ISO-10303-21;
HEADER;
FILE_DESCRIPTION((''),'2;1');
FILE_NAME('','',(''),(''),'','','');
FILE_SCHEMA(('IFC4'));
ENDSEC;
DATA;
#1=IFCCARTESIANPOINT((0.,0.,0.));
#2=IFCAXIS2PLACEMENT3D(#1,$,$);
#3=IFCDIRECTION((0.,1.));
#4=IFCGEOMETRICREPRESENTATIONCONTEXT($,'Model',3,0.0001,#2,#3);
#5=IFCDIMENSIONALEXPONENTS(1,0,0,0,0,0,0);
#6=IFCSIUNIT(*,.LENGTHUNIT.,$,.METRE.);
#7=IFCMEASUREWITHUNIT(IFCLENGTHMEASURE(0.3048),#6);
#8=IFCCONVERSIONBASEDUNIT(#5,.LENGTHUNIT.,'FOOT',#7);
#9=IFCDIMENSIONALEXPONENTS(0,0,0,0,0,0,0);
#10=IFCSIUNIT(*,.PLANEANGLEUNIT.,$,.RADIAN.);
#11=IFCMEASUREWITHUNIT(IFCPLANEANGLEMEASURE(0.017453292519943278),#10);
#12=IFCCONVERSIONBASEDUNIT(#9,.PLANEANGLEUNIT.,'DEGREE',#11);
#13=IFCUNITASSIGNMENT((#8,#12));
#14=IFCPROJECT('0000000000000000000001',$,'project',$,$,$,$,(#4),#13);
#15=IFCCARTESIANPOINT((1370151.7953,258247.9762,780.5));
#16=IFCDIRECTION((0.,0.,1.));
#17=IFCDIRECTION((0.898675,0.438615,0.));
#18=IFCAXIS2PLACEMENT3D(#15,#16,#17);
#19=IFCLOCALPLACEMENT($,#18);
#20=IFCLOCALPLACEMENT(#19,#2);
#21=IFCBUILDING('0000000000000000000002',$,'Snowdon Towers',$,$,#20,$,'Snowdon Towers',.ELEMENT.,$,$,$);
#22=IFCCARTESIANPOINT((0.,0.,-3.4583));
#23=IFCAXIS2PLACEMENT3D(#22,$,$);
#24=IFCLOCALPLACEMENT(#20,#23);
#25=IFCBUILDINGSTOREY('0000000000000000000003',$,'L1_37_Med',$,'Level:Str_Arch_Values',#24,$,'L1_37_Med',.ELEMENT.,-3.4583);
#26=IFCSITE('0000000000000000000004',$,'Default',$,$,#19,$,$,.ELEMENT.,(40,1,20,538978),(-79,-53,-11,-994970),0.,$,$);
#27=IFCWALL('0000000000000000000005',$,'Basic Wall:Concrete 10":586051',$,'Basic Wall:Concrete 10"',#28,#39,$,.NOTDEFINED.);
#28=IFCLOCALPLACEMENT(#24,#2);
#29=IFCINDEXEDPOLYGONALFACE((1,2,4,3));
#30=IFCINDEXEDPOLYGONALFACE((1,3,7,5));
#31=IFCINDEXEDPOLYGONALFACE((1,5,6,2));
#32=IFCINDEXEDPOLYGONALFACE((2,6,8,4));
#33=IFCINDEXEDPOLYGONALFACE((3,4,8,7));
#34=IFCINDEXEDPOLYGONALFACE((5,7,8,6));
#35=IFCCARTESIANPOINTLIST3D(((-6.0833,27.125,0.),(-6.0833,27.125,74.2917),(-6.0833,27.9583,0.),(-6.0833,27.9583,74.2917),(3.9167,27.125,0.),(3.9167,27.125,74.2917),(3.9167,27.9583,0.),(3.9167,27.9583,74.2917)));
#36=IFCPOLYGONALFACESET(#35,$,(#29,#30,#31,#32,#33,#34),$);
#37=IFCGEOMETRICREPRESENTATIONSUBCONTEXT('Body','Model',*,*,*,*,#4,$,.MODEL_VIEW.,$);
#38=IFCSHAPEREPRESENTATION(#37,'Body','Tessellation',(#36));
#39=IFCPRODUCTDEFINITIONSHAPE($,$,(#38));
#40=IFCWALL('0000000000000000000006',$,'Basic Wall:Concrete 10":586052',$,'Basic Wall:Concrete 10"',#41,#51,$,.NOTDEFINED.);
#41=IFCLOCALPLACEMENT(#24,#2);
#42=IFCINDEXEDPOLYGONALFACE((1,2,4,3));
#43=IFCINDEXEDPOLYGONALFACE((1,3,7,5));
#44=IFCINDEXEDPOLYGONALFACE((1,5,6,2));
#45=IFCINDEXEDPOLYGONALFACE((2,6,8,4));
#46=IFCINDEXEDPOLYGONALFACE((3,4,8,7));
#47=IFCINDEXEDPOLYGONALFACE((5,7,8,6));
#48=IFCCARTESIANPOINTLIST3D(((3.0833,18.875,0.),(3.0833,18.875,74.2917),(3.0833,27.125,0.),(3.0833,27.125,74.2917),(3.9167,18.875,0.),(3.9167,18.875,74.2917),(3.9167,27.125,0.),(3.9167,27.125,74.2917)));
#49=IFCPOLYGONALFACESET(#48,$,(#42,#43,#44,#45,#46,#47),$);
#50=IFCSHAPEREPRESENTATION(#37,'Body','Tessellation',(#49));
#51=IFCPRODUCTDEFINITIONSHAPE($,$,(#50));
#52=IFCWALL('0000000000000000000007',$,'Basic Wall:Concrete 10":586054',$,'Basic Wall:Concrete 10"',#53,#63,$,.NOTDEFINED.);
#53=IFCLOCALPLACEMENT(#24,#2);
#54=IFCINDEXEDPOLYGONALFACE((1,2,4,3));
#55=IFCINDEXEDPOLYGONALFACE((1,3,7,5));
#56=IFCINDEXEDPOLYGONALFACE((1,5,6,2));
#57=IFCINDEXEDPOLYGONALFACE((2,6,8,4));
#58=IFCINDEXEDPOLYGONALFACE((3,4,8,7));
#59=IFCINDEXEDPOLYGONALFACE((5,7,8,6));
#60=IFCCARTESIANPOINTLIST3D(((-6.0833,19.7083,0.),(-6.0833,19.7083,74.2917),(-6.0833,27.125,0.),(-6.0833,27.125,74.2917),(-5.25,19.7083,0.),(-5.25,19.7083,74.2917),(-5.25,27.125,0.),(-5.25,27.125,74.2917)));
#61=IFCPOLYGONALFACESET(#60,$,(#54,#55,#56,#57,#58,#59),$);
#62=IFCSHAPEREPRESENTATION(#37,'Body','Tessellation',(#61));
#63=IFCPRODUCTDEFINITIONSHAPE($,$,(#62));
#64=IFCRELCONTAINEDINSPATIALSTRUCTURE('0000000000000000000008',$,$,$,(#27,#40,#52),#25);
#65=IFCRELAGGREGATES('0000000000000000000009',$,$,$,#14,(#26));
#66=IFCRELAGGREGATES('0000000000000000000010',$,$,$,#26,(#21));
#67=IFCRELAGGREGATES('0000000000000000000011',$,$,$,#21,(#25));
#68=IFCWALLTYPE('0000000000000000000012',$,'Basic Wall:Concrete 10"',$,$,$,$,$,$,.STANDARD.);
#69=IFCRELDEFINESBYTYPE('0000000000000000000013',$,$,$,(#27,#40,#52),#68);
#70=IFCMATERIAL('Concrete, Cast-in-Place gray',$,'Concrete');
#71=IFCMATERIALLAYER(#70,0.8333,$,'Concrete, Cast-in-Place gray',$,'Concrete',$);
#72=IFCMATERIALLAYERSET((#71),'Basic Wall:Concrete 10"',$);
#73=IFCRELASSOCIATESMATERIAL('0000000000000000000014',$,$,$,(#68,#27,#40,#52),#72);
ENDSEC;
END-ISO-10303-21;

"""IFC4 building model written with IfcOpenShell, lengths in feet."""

from ifc_helpers import new_model, entity, si_unit, converted_unit, direction, frame, frame_2d, origin, place, context, subcontext, project, spatial, rectangle, extrude, material, layer, layer_set, layer_usage, type_object, element, save


model = new_model("IFC4")

# Units and contexts
model_context = context("Model", 3, precision=0.0001, world=origin(), true_north=direction((0.0, 1.0)))
body_context = subcontext(model_context, "Body", "Model", "MODEL_VIEW")
ifc_project = project(units=[converted_unit("LENGTHUNIT", "FOOT", entity("IfcLengthMeasure", 0.3048), si_unit("LENGTHUNIT", "METRE"), dimensions=[1, 0, 0, 0, 0, 0, 0]), converted_unit("PLANEANGLEUNIT", "DEGREE", entity("IfcPlaneAngleMeasure", 0.017453292519943278), si_unit("PLANEANGLEUNIT", "RADIAN"), dimensions=[0, 0, 0, 0, 0, 0, 0])], contexts=[model_context])

# Site, building, storey
site_placement = place(None, frame((1370151.7953, 258247.9762, 780.5), z_axis=(0.0, 0.0, 1.0), x_axis=(0.898675, 0.438615, 0.0)))
site = spatial("IfcSite", under=ifc_project, at=site_placement, Name="Default", CompositionType="ELEMENT", RefLatitude=(40, 1, 20, 538978), RefLongitude=(-79, -53, -11, -994970), RefElevation=0.0)
building_placement = place(site_placement, origin())
building = spatial("IfcBuilding", under=site, at=building_placement, Name="Snowdon Towers", LongName="Snowdon Towers", CompositionType="ELEMENT")
storey_placement = place(building_placement, frame((0.0, 0.0, -3.4583)))
storey = spatial("IfcBuildingStorey", under=building, at=storey_placement, Name="L1_37_Med", ObjectType="Level:Str_Arch_Values", LongName="L1_37_Med", CompositionType="ELEMENT", Elevation=-3.4583)

# Walls
ifc_material = material(Name="Concrete, Cast-in-Place gray", Category="Concrete")
ifc_layer_1 = layer(ifc_material, 0.8333, Name="Concrete, Cast-in-Place gray", Category="Concrete")
ifc_layer_set_1 = layer_set([ifc_layer_1], Name="Basic Wall:Concrete 10\"")
ifc_layer_usage_1 = layer_usage(ifc_layer_set_1, "AXIS2", "POSITIVE", -0.4167)
wall_type_1 = type_object("IfcWallType", Name="Basic Wall:Concrete 10\"", PredefinedType="STANDARD", material=ifc_layer_set_1)
wall_1_placement = place(storey_placement, frame((-6.0833, 27.5417, 0.0)))
element("IfcWall", 1, at=wall_1_placement, inside=storey, type_object=wall_type_1, material=ifc_layer_usage_1, Name="Basic Wall:Concrete 10\":586051", ObjectType="Basic Wall:Concrete 10\"", PredefinedType="NOTDEFINED", context=body_context, shape_type="SweptSolid", body=[
    extrude(rectangle(XDim=10.0, YDim=0.8333, at=frame_2d((5.0, 0.0), x_axis=(-1.0, 0.0))), origin(), (0.0, 0.0, 1.0), 74.2917),
])
ifc_layer_usage_2 = layer_usage(ifc_layer_set_1, "AXIS2", "POSITIVE", -0.4167)
wall_2_placement = place(storey_placement, frame((3.5, 27.125, 0.0), z_axis=(0.0, 0.0, 1.0), x_axis=(0.0, -1.0, 0.0)))
element("IfcWall", 2, at=wall_2_placement, inside=storey, type_object=wall_type_1, material=ifc_layer_usage_2, Name="Basic Wall:Concrete 10\":586052", ObjectType="Basic Wall:Concrete 10\"", PredefinedType="NOTDEFINED", context=body_context, shape_type="SweptSolid", body=[
    extrude(rectangle(XDim=8.25, YDim=0.8333, at=frame_2d((4.125, 0.0), x_axis=(-1.0, 0.0))), origin(), (0.0, 0.0, 1.0), 74.2917),
])

# Wall
ifc_layer_usage_3 = layer_usage(ifc_layer_set_1, "AXIS2", "POSITIVE", -0.4167)
wall_3_placement = place(storey_placement, frame((-5.6667, 19.7083, 0.0), z_axis=(0.0, 0.0, 1.0), x_axis=(0.0, 1.0, 0.0)))
element("IfcWall", 3, at=wall_3_placement, inside=storey, type_object=wall_type_1, material=ifc_layer_usage_3, Name="Basic Wall:Concrete 10\":586054", ObjectType="Basic Wall:Concrete 10\"", PredefinedType="NOTDEFINED", context=body_context, shape_type="SweptSolid", body=[
    extrude(rectangle(XDim=7.4167, YDim=0.8333, at=frame_2d((3.7083, 0.0), x_axis=(-1.0, 0.0))), origin(), (0.0, 0.0, 1.0), 74.2917),
])

save(model, "model.ifc")
